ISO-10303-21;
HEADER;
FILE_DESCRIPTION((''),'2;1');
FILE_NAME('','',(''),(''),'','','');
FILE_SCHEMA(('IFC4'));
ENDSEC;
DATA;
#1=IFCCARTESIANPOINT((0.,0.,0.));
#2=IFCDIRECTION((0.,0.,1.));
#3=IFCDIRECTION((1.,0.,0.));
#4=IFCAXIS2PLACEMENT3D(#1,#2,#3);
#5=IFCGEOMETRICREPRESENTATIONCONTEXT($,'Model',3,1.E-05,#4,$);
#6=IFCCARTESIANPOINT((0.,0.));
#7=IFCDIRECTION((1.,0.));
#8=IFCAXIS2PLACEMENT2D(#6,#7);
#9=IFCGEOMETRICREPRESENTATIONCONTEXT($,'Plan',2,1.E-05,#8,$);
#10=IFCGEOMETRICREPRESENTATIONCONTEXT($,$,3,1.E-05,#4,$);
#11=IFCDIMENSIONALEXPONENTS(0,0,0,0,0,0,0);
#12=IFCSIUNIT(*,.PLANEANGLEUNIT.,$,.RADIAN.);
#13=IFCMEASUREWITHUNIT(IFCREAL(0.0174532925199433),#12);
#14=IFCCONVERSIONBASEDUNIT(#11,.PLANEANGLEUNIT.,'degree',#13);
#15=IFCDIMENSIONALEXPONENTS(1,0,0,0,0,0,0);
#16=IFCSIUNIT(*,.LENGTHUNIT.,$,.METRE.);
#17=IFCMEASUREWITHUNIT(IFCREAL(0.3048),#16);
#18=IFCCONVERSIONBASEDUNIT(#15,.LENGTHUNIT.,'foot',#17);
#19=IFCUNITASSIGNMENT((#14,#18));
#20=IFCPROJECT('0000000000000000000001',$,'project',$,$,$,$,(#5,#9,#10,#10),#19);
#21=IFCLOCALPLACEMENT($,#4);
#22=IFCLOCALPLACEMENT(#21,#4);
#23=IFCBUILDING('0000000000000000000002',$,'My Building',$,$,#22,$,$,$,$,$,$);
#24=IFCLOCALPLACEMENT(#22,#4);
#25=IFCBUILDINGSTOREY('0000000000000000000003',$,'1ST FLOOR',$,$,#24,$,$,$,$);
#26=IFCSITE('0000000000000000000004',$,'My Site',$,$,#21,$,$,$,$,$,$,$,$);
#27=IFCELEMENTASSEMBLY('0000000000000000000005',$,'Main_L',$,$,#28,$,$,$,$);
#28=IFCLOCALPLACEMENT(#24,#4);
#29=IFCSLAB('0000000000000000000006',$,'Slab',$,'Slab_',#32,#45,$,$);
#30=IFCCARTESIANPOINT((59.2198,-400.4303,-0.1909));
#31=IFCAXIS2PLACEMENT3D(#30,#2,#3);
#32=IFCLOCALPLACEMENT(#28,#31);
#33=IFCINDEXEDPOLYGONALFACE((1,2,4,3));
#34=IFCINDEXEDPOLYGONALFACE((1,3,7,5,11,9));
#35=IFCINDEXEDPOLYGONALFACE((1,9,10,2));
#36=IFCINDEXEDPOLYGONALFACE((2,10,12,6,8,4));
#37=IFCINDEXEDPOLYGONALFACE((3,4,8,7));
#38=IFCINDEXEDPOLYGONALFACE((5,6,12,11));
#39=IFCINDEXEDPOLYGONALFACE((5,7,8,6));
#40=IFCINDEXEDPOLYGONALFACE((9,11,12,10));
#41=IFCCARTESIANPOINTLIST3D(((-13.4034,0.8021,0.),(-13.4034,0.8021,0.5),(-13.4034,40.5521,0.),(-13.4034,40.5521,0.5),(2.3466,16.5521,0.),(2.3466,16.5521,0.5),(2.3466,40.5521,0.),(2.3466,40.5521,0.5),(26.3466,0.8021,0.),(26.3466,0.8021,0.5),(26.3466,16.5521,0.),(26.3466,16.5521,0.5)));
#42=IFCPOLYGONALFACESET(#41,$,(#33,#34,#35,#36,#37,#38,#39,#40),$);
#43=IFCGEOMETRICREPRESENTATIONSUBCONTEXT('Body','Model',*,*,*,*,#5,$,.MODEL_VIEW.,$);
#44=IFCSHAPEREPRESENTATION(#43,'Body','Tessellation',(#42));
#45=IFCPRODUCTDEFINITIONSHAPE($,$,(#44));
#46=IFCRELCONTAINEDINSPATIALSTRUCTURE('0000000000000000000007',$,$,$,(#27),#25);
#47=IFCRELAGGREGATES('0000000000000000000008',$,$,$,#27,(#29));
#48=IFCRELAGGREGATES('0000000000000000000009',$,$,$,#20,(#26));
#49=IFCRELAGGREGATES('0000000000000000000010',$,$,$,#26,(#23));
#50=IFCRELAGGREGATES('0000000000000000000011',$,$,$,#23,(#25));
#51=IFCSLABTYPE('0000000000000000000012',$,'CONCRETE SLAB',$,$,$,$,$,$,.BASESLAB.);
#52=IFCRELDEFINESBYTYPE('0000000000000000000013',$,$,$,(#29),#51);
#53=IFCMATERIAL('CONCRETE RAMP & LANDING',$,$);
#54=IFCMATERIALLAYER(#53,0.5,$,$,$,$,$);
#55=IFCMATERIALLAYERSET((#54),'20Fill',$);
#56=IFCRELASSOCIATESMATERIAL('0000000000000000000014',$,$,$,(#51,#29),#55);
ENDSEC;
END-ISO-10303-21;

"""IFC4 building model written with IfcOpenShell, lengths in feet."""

from ifc_helpers import new_model, entity, si_unit, converted_unit, frame, origin_with_axes, origin_2d_with_axis, place, context, subcontext, project, spatial, line, indexed_curve, outline, extrude, material, layer, layer_set, layer_usage, type_object, element, aggregate, save


model = new_model("IFC4")

# Units and contexts
model_context = context("Model", 3, precision=1e-05, world=origin_with_axes())
plan_context = context("Plan", 2, precision=1e-05, world=origin_2d_with_axis())
context_of_model = context(None, 3, precision=1e-05, world=origin_with_axes())
body_context = subcontext(model_context, "Body", "Model", "MODEL_VIEW")
ifc_project = project(units=[converted_unit("PLANEANGLEUNIT", "degree", entity("IfcReal", 0.0174532925199433), si_unit("PLANEANGLEUNIT", "RADIAN"), dimensions=[0, 0, 0, 0, 0, 0, 0]), converted_unit("LENGTHUNIT", "foot", entity("IfcReal", 0.3048), si_unit("LENGTHUNIT", "METRE"), dimensions=[1, 0, 0, 0, 0, 0, 0])], contexts=[model_context, plan_context, context_of_model, context_of_model])

# Site, building, storey
site_placement = place(None, origin_with_axes())
site = spatial("IfcSite", under=ifc_project, at=site_placement, Name="My Site")
building_placement = place(site_placement, origin_with_axes())
building = spatial("IfcBuilding", under=site, at=building_placement, Name="My Building")
storey_placement = place(building_placement, origin_with_axes())
storey = spatial("IfcBuildingStorey", under=building, at=storey_placement, Name="1ST FLOOR")

# Element assembly, slab
assembly_placement = place(storey_placement, origin_with_axes())
assembly = element("IfcElementAssembly", 1, at=assembly_placement, inside=storey, Name="Main_L")
ifc_material_1 = material(Name="CONCRETE RAMP & LANDING")
ifc_layer = layer(ifc_material_1, 0.5)
ifc_layer_set = layer_set([ifc_layer], Name="20Fill")
ifc_layer_usage = layer_usage(ifc_layer_set, "AXIS3", "POSITIVE", 0.0)
slab_type = type_object("IfcSlabType", Name="CONCRETE SLAB", PredefinedType="BASESLAB", material=ifc_layer_set)
slab_placement = place(assembly_placement, frame((59.2198, -400.4303, -0.1909), z_axis=(0.0, 0.0, 1.0), x_axis=(1.0, 0.0, 0.0)))
slab = element("IfcSlab", 2, at=slab_placement, type_object=slab_type, material=ifc_layer_usage, Name="Slab", ObjectType="Slab_", context=body_context, shape_type="SweptSolid", body=[
    extrude(outline(indexed_curve([(-13.4034, 0.8021), (26.3466, 0.8021), (26.3466, 16.5521), (2.3466, 16.5521), (2.3466, 40.5521), (-13.4034, 40.5521)], segments=[line(5, 4), line(4, 3), line(3, 2), line(2, 1), line(1, 6), line(6, 5)], self_intersect=False)), None, (0.0, 0.0, 1.0), 0.5),
])
aggregate(assembly, [slab])

save(model, "model.ifc")
